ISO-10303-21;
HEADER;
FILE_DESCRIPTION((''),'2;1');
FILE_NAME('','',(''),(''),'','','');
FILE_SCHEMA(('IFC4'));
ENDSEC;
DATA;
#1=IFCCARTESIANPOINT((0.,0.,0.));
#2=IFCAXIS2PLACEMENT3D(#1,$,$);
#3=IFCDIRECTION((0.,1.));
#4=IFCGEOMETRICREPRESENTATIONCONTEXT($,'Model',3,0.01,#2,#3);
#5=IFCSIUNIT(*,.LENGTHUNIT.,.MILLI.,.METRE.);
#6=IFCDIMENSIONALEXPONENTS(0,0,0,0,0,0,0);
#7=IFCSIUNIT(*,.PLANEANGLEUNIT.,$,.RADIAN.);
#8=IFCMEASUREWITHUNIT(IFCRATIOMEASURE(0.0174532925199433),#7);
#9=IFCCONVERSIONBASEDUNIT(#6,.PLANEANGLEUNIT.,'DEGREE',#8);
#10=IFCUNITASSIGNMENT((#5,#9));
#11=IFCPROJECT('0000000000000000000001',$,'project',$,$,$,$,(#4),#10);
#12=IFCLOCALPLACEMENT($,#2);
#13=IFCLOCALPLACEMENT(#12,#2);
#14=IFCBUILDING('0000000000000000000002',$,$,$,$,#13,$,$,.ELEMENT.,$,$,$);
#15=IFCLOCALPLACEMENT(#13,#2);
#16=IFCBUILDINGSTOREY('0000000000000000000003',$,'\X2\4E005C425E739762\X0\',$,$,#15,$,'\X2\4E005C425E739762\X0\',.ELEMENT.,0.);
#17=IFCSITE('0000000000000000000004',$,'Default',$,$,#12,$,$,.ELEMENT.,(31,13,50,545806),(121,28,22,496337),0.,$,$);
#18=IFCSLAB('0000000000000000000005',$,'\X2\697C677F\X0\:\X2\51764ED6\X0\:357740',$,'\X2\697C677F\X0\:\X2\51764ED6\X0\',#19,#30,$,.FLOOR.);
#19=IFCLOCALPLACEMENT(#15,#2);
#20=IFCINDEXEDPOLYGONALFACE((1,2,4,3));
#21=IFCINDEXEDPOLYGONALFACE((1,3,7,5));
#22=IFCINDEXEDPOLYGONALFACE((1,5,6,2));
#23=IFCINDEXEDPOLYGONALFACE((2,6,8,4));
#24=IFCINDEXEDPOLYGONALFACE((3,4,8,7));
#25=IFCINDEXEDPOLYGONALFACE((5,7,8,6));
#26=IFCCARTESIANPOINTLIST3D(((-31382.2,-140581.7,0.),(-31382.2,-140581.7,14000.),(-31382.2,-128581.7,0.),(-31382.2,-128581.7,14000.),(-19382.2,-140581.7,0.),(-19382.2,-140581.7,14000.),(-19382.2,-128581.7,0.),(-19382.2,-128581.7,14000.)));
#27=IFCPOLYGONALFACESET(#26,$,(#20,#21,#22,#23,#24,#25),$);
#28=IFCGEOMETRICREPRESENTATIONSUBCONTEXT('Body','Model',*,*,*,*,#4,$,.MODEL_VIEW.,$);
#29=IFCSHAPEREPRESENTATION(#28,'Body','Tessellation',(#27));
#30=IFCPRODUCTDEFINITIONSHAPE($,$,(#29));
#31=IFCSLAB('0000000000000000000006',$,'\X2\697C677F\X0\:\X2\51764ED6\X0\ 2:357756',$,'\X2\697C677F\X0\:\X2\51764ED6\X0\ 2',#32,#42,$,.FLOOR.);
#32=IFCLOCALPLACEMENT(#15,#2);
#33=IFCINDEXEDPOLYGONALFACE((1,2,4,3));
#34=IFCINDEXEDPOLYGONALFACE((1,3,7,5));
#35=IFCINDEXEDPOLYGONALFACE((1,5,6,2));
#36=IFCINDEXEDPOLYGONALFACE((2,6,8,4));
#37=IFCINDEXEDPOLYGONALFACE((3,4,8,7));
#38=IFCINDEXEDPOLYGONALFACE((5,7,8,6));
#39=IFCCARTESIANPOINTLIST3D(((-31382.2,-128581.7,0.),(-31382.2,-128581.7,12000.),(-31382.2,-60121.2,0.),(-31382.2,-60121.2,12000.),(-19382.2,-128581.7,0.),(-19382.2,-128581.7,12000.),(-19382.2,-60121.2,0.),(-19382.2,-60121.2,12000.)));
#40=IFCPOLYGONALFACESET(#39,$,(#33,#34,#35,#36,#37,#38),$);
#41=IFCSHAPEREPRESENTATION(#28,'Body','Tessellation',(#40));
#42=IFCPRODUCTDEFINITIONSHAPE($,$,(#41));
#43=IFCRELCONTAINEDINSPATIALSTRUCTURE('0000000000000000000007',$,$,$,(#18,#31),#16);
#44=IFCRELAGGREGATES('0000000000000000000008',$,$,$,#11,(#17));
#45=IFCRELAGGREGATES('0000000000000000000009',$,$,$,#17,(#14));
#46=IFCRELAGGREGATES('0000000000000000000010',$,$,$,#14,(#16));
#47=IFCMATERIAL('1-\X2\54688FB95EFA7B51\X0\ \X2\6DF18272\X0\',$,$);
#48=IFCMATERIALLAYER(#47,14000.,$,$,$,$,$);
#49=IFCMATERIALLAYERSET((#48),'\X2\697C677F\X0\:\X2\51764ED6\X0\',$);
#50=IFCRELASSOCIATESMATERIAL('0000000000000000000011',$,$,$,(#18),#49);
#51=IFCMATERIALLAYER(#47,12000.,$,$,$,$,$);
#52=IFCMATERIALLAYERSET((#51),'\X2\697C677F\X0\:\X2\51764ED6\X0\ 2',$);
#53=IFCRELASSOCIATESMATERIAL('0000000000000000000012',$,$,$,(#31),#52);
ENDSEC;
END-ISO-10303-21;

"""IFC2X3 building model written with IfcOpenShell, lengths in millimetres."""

from ifc_helpers import new_model, entity, si_unit, converted_unit, direction, frame, frame_2d, origin, place, context, subcontext, project, spatial, rectangle, extrude, material, layer, layer_set, layer_usage, element, save


model = new_model("IFC2X3")

# Units and contexts
model_context = context("Model", 3, precision=0.01, world=origin(), true_north=direction((0.0, 1.0)))
body_context = subcontext(model_context, "Body", "Model", "MODEL_VIEW")
ifc_project = project(units=[si_unit("LENGTHUNIT", "METRE", prefix="MILLI"), converted_unit("PLANEANGLEUNIT", "DEGREE", entity("IfcRatioMeasure", 0.0174532925199433), si_unit("PLANEANGLEUNIT", "RADIAN"), dimensions=[0, 0, 0, 0, 0, 0, 0])], contexts=[model_context])

# Site, building, storey
site_placement = place(None, origin())
site = spatial("IfcSite", under=ifc_project, at=site_placement, Name="Default", CompositionType="ELEMENT", RefLatitude=(31, 13, 50, 545806), RefLongitude=(121, 28, 22, 496337), RefElevation=0.0)
building_placement = place(site_placement, origin())
building = spatial("IfcBuilding", under=site, at=building_placement, CompositionType="ELEMENT")
storey_placement = place(building_placement, origin())
storey = spatial("IfcBuildingStorey", under=building, at=storey_placement, Name="一层平面", LongName="一层平面", CompositionType="ELEMENT", Elevation=0.0)

# Slabs
ifc_material_1 = material(Name="1-周边建筑 深色")
ifc_layer_1 = layer(ifc_material_1, 14000.0)
ifc_layer_set_1 = layer_set([ifc_layer_1], Name="楼板:其他")
ifc_layer_usage_1 = layer_usage(ifc_layer_set_1, "AXIS3", "POSITIVE", 0.0)
slab_1_placement = place(storey_placement, origin())
element("IfcSlab", 1, at=slab_1_placement, inside=storey, material=ifc_layer_usage_1, Name="楼板:其他:357740", ObjectType="楼板:其他", PredefinedType="FLOOR", context=body_context, shape_type="SweptSolid", body=[
    extrude(rectangle(XDim=12000.0, YDim=12000.0, at=frame_2d((0.0, 0.0), x_axis=(1.0, 0.0))), frame((-25382.2, -134581.7, 14000.0), z_axis=(0.0, 0.0, -1.0), x_axis=(0.0, 1.0, 0.0)), (0.0, 0.0, 1.0), 14000.0),
])
ifc_layer_2 = layer(ifc_material_1, 12000.0)
ifc_layer_set_2 = layer_set([ifc_layer_2], Name="楼板:其他 2")
ifc_layer_usage_2 = layer_usage(ifc_layer_set_2, "AXIS3", "POSITIVE", 0.0)
slab_2_placement = place(storey_placement, origin())
element("IfcSlab", 2, at=slab_2_placement, inside=storey, material=ifc_layer_usage_2, Name="楼板:其他 2:357756", ObjectType="楼板:其他 2", PredefinedType="FLOOR", context=body_context, shape_type="SweptSolid", body=[
    extrude(rectangle(XDim=68460.5, YDim=12000.0, at=frame_2d((0.0, 0.0), x_axis=(1.0, 0.0))), frame((-25382.2, -94351.5, 12000.0), z_axis=(0.0, 0.0, -1.0), x_axis=(0.0, 1.0, 0.0)), (0.0, 0.0, 1.0), 12000.0),
])

save(model, "model.ifc")
